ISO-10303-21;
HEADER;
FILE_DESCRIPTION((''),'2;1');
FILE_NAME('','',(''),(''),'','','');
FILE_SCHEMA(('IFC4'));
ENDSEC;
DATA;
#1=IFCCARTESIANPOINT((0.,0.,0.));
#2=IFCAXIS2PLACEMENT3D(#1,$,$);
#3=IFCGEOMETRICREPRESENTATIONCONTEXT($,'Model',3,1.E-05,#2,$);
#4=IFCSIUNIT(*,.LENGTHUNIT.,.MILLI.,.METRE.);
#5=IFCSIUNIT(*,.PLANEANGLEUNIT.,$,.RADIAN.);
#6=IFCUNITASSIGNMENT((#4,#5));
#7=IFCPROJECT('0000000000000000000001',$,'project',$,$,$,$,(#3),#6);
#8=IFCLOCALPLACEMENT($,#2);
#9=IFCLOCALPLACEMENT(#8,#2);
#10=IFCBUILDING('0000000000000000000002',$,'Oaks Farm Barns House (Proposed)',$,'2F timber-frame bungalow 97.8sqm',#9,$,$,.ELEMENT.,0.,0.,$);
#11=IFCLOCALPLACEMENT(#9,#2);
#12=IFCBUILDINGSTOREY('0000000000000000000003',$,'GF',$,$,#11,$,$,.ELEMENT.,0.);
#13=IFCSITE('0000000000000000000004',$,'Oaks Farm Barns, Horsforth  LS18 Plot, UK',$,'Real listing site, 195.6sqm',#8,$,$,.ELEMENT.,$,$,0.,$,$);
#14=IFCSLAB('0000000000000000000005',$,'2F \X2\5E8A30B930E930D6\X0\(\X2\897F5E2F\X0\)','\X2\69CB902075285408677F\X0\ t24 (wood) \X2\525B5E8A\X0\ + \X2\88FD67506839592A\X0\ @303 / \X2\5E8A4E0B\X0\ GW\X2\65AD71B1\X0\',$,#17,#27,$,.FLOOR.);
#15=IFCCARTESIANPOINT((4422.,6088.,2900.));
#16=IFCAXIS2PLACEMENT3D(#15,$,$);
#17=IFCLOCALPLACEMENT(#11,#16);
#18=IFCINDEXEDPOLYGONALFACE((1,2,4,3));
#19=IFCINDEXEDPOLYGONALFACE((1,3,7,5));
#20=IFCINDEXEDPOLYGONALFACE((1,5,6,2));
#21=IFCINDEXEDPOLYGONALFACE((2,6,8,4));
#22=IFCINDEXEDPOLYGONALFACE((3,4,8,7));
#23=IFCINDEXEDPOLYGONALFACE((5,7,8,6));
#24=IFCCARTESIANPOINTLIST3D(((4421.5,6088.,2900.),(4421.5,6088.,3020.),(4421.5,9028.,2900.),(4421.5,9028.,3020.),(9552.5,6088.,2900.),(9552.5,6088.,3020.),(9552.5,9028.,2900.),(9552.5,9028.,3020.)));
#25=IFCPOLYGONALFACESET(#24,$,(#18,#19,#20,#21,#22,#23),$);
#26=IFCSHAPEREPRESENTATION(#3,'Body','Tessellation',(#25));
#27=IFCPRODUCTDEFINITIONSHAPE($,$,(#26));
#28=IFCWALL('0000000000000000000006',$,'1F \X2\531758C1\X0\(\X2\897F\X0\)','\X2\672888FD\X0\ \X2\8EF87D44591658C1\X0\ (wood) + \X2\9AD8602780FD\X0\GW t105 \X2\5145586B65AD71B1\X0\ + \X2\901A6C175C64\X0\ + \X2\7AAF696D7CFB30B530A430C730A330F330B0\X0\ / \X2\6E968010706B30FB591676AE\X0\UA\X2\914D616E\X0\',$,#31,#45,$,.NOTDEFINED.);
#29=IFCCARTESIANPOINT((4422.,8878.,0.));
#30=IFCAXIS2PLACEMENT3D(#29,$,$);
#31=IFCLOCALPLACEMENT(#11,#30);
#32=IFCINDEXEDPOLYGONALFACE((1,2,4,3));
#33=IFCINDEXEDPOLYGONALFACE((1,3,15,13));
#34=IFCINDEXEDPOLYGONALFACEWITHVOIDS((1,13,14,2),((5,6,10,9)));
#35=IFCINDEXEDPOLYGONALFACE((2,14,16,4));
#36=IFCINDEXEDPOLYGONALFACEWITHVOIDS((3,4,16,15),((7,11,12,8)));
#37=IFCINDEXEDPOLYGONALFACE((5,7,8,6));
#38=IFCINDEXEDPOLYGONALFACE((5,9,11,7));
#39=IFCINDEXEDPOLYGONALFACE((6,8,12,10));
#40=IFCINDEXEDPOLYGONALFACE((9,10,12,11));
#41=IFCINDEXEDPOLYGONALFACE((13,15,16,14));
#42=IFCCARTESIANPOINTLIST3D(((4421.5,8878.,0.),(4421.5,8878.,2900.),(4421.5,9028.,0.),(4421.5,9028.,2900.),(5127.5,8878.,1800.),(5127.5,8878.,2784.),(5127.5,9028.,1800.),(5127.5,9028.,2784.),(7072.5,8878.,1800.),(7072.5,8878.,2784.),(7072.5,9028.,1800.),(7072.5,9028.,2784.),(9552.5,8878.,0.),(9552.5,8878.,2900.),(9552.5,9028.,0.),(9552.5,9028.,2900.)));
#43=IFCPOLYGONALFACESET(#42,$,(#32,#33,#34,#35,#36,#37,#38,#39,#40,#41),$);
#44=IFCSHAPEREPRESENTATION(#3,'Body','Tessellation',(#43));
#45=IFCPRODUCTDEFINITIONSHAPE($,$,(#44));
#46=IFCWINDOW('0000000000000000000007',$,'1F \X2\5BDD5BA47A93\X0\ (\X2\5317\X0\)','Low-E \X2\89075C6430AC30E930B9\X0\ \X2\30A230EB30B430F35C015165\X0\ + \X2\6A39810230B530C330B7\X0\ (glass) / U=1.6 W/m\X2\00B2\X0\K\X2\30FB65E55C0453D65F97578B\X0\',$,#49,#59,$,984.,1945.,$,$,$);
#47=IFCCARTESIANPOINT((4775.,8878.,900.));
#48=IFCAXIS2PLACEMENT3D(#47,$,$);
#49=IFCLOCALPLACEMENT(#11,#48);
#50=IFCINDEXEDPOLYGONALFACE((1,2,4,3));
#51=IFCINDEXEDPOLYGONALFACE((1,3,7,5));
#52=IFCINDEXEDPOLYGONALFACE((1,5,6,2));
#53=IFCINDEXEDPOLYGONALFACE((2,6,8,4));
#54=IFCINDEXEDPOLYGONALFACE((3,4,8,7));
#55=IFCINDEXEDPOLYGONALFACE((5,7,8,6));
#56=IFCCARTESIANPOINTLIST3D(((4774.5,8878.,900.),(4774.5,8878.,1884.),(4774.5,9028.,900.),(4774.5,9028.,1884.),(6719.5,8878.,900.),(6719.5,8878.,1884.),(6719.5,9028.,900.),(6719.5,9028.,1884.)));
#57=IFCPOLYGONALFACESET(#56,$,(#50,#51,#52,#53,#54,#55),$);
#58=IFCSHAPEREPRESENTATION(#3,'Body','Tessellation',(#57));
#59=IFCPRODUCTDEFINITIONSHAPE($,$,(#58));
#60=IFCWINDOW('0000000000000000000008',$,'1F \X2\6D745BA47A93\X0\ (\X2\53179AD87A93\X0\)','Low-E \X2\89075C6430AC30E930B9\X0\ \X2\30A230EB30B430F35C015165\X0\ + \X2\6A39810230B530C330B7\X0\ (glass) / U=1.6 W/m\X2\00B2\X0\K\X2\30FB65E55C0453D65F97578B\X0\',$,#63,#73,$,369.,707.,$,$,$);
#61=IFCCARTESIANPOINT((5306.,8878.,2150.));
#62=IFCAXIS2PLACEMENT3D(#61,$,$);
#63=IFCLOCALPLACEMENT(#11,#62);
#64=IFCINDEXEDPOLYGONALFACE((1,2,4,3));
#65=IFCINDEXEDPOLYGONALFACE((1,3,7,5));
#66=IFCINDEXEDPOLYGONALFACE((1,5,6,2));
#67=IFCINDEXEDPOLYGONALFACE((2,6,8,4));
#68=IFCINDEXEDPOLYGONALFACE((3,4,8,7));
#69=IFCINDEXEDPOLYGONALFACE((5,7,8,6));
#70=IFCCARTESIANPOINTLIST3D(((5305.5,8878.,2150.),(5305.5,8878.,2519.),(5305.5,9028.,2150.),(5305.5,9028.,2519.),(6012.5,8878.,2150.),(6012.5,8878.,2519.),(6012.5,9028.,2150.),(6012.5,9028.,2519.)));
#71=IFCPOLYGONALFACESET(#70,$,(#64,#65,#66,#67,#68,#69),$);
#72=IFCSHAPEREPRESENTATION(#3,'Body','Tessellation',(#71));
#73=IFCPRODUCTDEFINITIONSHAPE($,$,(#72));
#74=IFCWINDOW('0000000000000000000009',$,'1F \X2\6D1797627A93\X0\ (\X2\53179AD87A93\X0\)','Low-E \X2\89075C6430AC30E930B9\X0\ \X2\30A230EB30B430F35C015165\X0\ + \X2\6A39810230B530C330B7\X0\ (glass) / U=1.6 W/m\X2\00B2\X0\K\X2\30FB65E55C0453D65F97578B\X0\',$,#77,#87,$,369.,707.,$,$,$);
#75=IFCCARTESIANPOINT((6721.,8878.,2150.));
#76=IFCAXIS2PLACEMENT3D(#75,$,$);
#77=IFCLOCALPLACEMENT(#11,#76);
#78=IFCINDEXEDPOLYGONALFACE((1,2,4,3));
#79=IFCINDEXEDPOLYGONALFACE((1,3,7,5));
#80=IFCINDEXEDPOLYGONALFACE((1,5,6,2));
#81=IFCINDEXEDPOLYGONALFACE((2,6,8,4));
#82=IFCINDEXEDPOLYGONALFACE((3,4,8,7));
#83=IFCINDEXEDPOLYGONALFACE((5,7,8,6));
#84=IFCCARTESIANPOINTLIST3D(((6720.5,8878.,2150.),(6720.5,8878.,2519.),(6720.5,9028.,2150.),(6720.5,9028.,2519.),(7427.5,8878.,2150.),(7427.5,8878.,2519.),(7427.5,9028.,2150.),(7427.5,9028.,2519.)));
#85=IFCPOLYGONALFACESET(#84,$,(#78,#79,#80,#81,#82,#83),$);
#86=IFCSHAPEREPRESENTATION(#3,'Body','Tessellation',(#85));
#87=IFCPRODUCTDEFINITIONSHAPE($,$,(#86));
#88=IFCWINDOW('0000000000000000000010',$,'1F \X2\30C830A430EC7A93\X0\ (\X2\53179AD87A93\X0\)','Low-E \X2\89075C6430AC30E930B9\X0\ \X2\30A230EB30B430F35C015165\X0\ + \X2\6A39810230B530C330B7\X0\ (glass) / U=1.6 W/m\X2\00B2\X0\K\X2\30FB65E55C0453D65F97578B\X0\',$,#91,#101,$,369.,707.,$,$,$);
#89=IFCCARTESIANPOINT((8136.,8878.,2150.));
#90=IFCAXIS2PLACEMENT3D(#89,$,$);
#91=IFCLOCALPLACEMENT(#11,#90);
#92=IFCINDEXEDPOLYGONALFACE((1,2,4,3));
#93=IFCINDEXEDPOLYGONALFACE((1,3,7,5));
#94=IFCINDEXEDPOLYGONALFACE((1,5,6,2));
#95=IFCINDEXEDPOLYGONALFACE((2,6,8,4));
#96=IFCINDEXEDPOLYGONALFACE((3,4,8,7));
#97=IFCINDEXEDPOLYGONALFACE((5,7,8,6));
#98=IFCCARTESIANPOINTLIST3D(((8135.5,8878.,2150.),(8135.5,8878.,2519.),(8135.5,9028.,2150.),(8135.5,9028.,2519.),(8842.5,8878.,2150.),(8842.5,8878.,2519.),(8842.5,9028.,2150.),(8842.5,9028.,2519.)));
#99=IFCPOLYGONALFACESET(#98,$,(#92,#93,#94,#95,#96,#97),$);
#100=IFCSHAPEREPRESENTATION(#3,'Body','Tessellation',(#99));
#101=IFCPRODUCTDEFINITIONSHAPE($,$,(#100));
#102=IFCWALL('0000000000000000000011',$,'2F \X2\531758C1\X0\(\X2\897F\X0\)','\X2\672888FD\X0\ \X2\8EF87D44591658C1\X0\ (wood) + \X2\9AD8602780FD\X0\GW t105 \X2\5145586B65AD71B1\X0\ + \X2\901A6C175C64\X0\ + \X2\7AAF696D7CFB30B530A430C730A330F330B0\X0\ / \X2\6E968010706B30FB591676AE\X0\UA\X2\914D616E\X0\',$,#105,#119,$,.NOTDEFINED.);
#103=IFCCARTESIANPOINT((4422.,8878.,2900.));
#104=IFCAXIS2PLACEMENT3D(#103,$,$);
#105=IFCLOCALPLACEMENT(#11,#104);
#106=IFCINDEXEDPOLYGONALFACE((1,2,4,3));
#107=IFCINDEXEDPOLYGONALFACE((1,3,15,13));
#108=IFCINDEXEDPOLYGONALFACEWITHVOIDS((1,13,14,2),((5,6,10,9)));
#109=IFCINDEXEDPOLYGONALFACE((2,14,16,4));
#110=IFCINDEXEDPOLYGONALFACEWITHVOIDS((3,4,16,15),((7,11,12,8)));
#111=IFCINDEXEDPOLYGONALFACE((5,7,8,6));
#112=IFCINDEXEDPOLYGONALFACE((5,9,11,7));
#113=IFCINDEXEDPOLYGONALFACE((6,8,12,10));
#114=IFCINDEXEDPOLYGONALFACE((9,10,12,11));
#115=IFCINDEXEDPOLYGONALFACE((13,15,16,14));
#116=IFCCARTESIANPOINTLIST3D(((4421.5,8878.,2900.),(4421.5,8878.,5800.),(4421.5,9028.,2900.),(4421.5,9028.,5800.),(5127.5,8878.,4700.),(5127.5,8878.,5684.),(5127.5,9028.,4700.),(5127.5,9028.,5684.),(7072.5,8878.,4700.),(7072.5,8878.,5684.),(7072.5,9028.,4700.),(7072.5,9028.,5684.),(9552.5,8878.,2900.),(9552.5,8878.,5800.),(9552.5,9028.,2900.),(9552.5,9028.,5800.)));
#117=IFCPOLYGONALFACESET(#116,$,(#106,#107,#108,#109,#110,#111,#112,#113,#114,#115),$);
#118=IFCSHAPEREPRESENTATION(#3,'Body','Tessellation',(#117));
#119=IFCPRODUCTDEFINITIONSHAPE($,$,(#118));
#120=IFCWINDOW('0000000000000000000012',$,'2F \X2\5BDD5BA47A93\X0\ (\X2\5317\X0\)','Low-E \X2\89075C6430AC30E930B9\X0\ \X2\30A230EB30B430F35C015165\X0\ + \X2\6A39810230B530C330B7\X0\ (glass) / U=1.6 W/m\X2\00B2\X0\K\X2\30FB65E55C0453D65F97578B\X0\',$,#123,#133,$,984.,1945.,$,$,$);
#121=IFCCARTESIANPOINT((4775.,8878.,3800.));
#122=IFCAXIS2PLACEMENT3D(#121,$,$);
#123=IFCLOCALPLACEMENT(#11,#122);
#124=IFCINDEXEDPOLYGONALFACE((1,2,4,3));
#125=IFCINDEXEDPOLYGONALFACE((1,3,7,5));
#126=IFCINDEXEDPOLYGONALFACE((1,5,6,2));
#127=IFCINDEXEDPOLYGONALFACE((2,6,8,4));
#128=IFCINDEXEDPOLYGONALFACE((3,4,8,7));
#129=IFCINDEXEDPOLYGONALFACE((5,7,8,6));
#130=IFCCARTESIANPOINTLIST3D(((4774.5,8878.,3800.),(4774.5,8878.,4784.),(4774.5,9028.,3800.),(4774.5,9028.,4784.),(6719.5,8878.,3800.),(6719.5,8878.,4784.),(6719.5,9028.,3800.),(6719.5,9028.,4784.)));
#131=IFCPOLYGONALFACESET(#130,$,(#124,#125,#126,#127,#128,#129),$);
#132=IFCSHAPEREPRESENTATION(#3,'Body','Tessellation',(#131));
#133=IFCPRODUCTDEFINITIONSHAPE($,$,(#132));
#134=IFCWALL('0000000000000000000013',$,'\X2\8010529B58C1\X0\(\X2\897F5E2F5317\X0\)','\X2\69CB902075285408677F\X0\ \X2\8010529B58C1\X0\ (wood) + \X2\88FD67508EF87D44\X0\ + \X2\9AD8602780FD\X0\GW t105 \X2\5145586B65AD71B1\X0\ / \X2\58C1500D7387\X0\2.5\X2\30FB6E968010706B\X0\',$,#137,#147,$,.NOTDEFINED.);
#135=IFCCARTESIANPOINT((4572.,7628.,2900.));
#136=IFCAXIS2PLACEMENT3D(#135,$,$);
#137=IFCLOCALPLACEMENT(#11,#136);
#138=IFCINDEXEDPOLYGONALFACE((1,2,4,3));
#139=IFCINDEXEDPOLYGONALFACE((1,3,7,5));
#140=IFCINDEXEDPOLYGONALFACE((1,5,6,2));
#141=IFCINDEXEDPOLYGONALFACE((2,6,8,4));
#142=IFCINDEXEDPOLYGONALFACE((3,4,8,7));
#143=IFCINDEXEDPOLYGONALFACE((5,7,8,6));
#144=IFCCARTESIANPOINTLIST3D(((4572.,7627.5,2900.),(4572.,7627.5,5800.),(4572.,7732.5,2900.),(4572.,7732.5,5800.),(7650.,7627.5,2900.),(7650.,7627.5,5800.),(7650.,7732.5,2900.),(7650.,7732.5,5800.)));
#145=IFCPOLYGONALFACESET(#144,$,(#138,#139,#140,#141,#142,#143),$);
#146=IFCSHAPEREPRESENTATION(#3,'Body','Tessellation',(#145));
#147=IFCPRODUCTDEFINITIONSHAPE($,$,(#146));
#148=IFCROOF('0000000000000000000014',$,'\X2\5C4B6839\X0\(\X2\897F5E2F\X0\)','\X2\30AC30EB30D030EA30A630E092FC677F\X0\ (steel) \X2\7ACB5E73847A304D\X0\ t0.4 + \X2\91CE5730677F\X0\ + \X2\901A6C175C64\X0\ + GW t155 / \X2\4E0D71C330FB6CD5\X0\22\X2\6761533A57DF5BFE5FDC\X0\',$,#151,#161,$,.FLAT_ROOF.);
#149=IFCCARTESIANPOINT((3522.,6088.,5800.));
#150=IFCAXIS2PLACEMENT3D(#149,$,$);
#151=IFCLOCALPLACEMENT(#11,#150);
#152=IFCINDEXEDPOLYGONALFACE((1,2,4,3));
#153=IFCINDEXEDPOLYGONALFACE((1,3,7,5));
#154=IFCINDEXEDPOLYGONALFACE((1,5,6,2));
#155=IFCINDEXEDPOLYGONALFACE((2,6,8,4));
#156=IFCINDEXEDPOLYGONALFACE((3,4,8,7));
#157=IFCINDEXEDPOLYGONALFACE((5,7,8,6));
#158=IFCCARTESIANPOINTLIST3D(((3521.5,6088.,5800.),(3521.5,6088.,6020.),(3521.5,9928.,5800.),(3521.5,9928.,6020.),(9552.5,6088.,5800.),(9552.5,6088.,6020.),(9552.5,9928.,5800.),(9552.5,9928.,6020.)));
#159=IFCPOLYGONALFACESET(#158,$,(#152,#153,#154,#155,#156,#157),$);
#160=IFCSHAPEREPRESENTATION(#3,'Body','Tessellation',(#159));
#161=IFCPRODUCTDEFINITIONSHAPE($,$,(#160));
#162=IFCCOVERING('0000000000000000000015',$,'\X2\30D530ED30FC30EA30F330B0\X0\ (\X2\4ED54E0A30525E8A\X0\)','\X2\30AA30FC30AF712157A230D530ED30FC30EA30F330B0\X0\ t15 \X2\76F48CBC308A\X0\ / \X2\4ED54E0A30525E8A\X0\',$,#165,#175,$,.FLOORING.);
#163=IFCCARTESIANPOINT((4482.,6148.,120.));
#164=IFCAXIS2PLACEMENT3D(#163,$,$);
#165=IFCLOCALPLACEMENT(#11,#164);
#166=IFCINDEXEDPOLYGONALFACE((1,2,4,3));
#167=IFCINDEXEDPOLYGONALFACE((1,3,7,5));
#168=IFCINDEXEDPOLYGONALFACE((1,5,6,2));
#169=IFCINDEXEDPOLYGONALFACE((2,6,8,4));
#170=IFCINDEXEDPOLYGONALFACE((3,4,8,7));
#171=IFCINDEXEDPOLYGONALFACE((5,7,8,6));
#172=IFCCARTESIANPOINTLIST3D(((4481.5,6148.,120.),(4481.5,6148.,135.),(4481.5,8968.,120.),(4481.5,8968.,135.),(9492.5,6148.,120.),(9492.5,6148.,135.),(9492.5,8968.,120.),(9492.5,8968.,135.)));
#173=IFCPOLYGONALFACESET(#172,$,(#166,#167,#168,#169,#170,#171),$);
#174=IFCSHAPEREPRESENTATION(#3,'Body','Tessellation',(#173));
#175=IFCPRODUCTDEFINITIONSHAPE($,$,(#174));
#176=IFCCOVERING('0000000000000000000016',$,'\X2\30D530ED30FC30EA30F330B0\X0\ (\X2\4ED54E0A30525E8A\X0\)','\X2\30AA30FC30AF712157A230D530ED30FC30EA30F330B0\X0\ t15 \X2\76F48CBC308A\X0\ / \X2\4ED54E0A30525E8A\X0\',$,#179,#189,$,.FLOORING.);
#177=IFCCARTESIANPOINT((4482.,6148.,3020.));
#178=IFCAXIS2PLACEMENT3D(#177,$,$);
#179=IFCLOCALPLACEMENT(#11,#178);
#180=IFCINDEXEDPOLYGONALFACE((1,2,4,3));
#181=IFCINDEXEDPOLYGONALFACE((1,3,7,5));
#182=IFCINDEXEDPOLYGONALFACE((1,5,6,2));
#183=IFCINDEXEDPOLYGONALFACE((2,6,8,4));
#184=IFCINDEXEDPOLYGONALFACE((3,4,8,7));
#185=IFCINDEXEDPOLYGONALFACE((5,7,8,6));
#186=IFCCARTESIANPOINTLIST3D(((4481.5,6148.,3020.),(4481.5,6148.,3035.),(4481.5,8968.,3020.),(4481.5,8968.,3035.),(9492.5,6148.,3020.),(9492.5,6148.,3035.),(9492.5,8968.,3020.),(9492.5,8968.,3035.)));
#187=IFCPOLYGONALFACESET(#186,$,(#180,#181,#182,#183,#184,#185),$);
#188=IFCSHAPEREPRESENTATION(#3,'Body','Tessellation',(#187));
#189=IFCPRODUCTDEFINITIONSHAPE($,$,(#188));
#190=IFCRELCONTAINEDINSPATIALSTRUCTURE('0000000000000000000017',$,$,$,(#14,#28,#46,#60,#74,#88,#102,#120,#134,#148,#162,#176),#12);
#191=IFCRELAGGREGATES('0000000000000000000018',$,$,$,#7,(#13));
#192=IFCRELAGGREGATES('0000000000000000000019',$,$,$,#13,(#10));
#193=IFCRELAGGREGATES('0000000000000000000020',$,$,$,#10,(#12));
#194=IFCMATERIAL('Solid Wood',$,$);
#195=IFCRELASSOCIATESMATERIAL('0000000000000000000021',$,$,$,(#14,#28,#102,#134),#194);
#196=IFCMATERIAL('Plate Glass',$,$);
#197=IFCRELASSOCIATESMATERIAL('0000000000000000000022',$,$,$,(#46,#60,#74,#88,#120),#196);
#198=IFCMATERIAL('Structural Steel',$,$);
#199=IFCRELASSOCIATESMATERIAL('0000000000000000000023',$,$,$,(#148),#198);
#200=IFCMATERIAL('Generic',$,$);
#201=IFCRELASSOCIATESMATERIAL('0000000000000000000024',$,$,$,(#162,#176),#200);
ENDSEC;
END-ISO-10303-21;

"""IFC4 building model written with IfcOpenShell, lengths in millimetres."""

from ifc_helpers import new_model, si_unit, frame, frame_2d, origin, place, context, project, spatial, rectangle, extrude, material, element, fill, save


model = new_model("IFC4")

# Units and contexts
model_context = context("Model", 3, precision=1e-05, world=origin())
ifc_project = project(units=[si_unit("LENGTHUNIT", "METRE", prefix="MILLI"), si_unit("PLANEANGLEUNIT", "RADIAN")], contexts=[model_context])

# Site, building, storey
site_placement = place(None, origin())
site = spatial("IfcSite", under=ifc_project, at=site_placement, Name="Oaks Farm Barns, Horsforth  LS18 Plot, UK", ObjectType="Real listing site, 195.6sqm", CompositionType="ELEMENT", RefElevation=0.0)
building_placement = place(site_placement, origin())
building = spatial("IfcBuilding", under=site, at=building_placement, Name="Oaks Farm Barns House (Proposed)", ObjectType="2F timber-frame bungalow 97.8sqm", CompositionType="ELEMENT", ElevationOfRefHeight=0.0, ElevationOfTerrain=0.0)
storey_placement = place(building_placement, origin())
storey = spatial("IfcBuildingStorey", under=building, at=storey_placement, Name="GF", CompositionType="ELEMENT", Elevation=0.0)

# Slab
ifc_material_1 = material(Name="Solid Wood")
slab_1_placement = place(storey_placement, frame((4422.0, 6088.0, 2900.0)))
element("IfcSlab", 1, at=slab_1_placement, inside=storey, material=ifc_material_1, Name="2F 床スラブ(西帯)", Description="構造用合板 t24 (wood) 剛床 + 製材根太 @303 / 床下 GW断熱", PredefinedType="FLOOR", context=model_context, shape_type="SweptSolid", body=[
    extrude(rectangle(XDim=5131.0, YDim=2940.0, at=frame_2d((2565.0, 1470.0))), frame((4422.0, 6088.0, 2900.0)), (0.0, 0.0, 1.0), 120.0),
])

# Wall, openings, windows
wall_1_placement = place(storey_placement, frame((4422.0, 8878.0, 0.0)))
wall_1 = element("IfcWall", 2, at=wall_1_placement, inside=storey, material=ifc_material_1, Name="1F 北壁(西)", Description="木製 軸組外壁 (wood) + 高性能GW t105 充填断熱 + 通気層 + 窯業系サイディング / 準耐火・外皮UA配慮", PredefinedType="NOTDEFINED", context=model_context, shape_type="SweptSolid", body=[
    extrude(rectangle(XDim=5131.0, YDim=150.0, at=frame_2d((2565.0, 75.0))), frame((4422.0, 8878.0, 0.0)), (0.0, 0.0, 1.0), 2900.0),
])
opening_1_placement = place(storey_placement, frame((4775.0, 8878.0, 900.0)))
opening_1 = element("IfcOpeningElement", 3, at=opening_1_placement, cuts=wall_1, PredefinedType="NOTDEFINED", context=model_context, shape_type="SweptSolid", body=[
    extrude(rectangle(XDim=1945.0, YDim=150.0, at=frame_2d((972.0, 75.0))), frame((4775.0, 8878.0, 900.0)), (0.0, 0.0, 1.0), 984.0),
])
opening_2_placement = place(storey_placement, frame((5306.0, 8878.0, 2150.0)))
opening_2 = element("IfcOpeningElement", 4, at=opening_2_placement, cuts=wall_1, PredefinedType="NOTDEFINED", context=model_context, shape_type="SweptSolid", body=[
    extrude(rectangle(XDim=707.0, YDim=150.0, at=frame_2d((353.0, 75.0))), frame((5306.0, 8878.0, 2150.0)), (0.0, 0.0, 1.0), 369.0),
])
opening_3_placement = place(storey_placement, frame((6721.0, 8878.0, 2150.0)))
opening_3 = element("IfcOpeningElement", 5, at=opening_3_placement, cuts=wall_1, PredefinedType="NOTDEFINED", context=model_context, shape_type="SweptSolid", body=[
    extrude(rectangle(XDim=707.0, YDim=150.0, at=frame_2d((353.0, 75.0))), frame((6721.0, 8878.0, 2150.0)), (0.0, 0.0, 1.0), 369.0),
])
opening_4_placement = place(storey_placement, frame((8136.0, 8878.0, 2150.0)))
opening_4 = element("IfcOpeningElement", 6, at=opening_4_placement, cuts=wall_1, PredefinedType="NOTDEFINED", context=model_context, shape_type="SweptSolid", body=[
    extrude(rectangle(XDim=707.0, YDim=150.0, at=frame_2d((353.0, 75.0))), frame((8136.0, 8878.0, 2150.0)), (0.0, 0.0, 1.0), 369.0),
])
ifc_material_2 = material(Name="Plate Glass")
window_1_placement = place(storey_placement, frame((4775.0, 8878.0, 900.0)))
window_1 = element("IfcWindow", 7, at=window_1_placement, inside=storey, material=ifc_material_2, Name="1F 寝室窓 (北)", Description="Low-E 複層ガラス アルゴン封入 + 樹脂サッシ (glass) / U=1.6 W/m²K・日射取得型", OverallHeight=984.0, OverallWidth=1945.0, context=model_context, shape_type="SweptSolid", body=[
    extrude(rectangle(XDim=1945.0, YDim=150.0, at=frame_2d((972.0, 75.0))), frame((4775.0, 8878.0, 900.0)), (0.0, 0.0, 1.0), 984.0),
])
fill(opening_1, window_1)
window_2_placement = place(storey_placement, frame((5306.0, 8878.0, 2150.0)))
window_2 = element("IfcWindow", 8, at=window_2_placement, inside=storey, material=ifc_material_2, Name="1F 浴室窓 (北高窓)", Description="Low-E 複層ガラス アルゴン封入 + 樹脂サッシ (glass) / U=1.6 W/m²K・日射取得型", OverallHeight=369.0, OverallWidth=707.0, context=model_context, shape_type="SweptSolid", body=[
    extrude(rectangle(XDim=707.0, YDim=150.0, at=frame_2d((353.0, 75.0))), frame((5306.0, 8878.0, 2150.0)), (0.0, 0.0, 1.0), 369.0),
])
fill(opening_2, window_2)
window_3_placement = place(storey_placement, frame((6721.0, 8878.0, 2150.0)))
window_3 = element("IfcWindow", 9, at=window_3_placement, inside=storey, material=ifc_material_2, Name="1F 洗面窓 (北高窓)", Description="Low-E 複層ガラス アルゴン封入 + 樹脂サッシ (glass) / U=1.6 W/m²K・日射取得型", OverallHeight=369.0, OverallWidth=707.0, context=model_context, shape_type="SweptSolid", body=[
    extrude(rectangle(XDim=707.0, YDim=150.0, at=frame_2d((353.0, 75.0))), frame((6721.0, 8878.0, 2150.0)), (0.0, 0.0, 1.0), 369.0),
])
fill(opening_3, window_3)
window_4_placement = place(storey_placement, frame((8136.0, 8878.0, 2150.0)))
window_4 = element("IfcWindow", 10, at=window_4_placement, inside=storey, material=ifc_material_2, Name="1F トイレ窓 (北高窓)", Description="Low-E 複層ガラス アルゴン封入 + 樹脂サッシ (glass) / U=1.6 W/m²K・日射取得型", OverallHeight=369.0, OverallWidth=707.0, context=model_context, shape_type="SweptSolid", body=[
    extrude(rectangle(XDim=707.0, YDim=150.0, at=frame_2d((353.0, 75.0))), frame((8136.0, 8878.0, 2150.0)), (0.0, 0.0, 1.0), 369.0),
])
fill(opening_4, window_4)

# Wall, opening, window
wall_2_placement = place(storey_placement, frame((4422.0, 8878.0, 2900.0)))
wall_2 = element("IfcWall", 11, at=wall_2_placement, inside=storey, material=ifc_material_1, Name="2F 北壁(西)", Description="木製 軸組外壁 (wood) + 高性能GW t105 充填断熱 + 通気層 + 窯業系サイディング / 準耐火・外皮UA配慮", PredefinedType="NOTDEFINED", context=model_context, shape_type="SweptSolid", body=[
    extrude(rectangle(XDim=5131.0, YDim=150.0, at=frame_2d((2565.0, 75.0))), frame((4422.0, 8878.0, 2900.0)), (0.0, 0.0, 1.0), 2900.0),
])
opening_5_placement = place(storey_placement, frame((4775.0, 8878.0, 3800.0)))
opening_5 = element("IfcOpeningElement", 12, at=opening_5_placement, cuts=wall_2, PredefinedType="NOTDEFINED", context=model_context, shape_type="SweptSolid", body=[
    extrude(rectangle(XDim=1945.0, YDim=150.0, at=frame_2d((972.0, 75.0))), frame((4775.0, 8878.0, 3800.0)), (0.0, 0.0, 1.0), 984.0),
])
window_5_placement = place(storey_placement, frame((4775.0, 8878.0, 3800.0)))
window_5 = element("IfcWindow", 13, at=window_5_placement, inside=storey, material=ifc_material_2, Name="2F 寝室窓 (北)", Description="Low-E 複層ガラス アルゴン封入 + 樹脂サッシ (glass) / U=1.6 W/m²K・日射取得型", OverallHeight=984.0, OverallWidth=1945.0, context=model_context, shape_type="SweptSolid", body=[
    extrude(rectangle(XDim=1945.0, YDim=150.0, at=frame_2d((972.0, 75.0))), frame((4775.0, 8878.0, 3800.0)), (0.0, 0.0, 1.0), 984.0),
])
fill(opening_5, window_5)

# Wall
wall_3_placement = place(storey_placement, frame((4572.0, 7628.0, 2900.0)))
element("IfcWall", 14, at=wall_3_placement, inside=storey, material=ifc_material_1, Name="耐力壁(西帯北)", Description="構造用合板 耐力壁 (wood) + 製材軸組 + 高性能GW t105 充填断熱 / 壁倍率2.5・準耐火", PredefinedType="NOTDEFINED", context=model_context, shape_type="SweptSolid", body=[
    extrude(rectangle(XDim=3078.0, YDim=105.0, at=frame_2d((1539.0, 52.0))), frame((4572.0, 7628.0, 2900.0)), (0.0, 0.0, 1.0), 2900.0),
])

# Roof
ifc_material_3 = material(Name="Structural Steel")
for number, where, name in (
    (15, (3522.0, 6088.0, 5800.0), "屋根(西帯)"),
):
    element("IfcRoof", number, at=place(storey_placement, frame(where)), inside=storey, material=ifc_material_3, Name=name, Description="ガルバリウム鋼板 (steel) 立平葺き t0.4 + 野地板 + 通気層 + GW t155 / 不燃・法22条区域対応", PredefinedType="FLAT_ROOF", context=model_context, shape_type="SweptSolid", body=[
        extrude(rectangle(XDim=6031.0, YDim=3840.0, at=frame_2d((3015.0, 1920.0))), frame((3522.0, 6088.0, 5800.0)), (0.0, 0.0, 1.0), 220.0),
    ])

# Coverings
ifc_material_4 = material(Name="Generic")
covering_1_placement = place(storey_placement, frame((4482.0, 6148.0, 120.0)))
element("IfcCovering", 16, at=covering_1_placement, inside=storey, material=ifc_material_4, Name="フローリング (仕上げ床)", Description="オーク無垢フローリング t15 直貼り / 仕上げ床", PredefinedType="FLOORING", context=model_context, shape_type="SweptSolid", body=[
    extrude(rectangle(XDim=5011.0, YDim=2820.0, at=frame_2d((2505.0, 1410.0))), frame((4482.0, 6148.0, 120.0)), (0.0, 0.0, 1.0), 15.0),
])
covering_2_placement = place(storey_placement, frame((4482.0, 6148.0, 3020.0)))
element("IfcCovering", 17, at=covering_2_placement, inside=storey, material=ifc_material_4, Name="フローリング (仕上げ床)", Description="オーク無垢フローリング t15 直貼り / 仕上げ床", PredefinedType="FLOORING", context=model_context, shape_type="SweptSolid", body=[
    extrude(rectangle(XDim=5011.0, YDim=2820.0, at=frame_2d((2505.0, 1410.0))), frame((4482.0, 6148.0, 3020.0)), (0.0, 0.0, 1.0), 15.0),
])

save(model, "model.ifc")
